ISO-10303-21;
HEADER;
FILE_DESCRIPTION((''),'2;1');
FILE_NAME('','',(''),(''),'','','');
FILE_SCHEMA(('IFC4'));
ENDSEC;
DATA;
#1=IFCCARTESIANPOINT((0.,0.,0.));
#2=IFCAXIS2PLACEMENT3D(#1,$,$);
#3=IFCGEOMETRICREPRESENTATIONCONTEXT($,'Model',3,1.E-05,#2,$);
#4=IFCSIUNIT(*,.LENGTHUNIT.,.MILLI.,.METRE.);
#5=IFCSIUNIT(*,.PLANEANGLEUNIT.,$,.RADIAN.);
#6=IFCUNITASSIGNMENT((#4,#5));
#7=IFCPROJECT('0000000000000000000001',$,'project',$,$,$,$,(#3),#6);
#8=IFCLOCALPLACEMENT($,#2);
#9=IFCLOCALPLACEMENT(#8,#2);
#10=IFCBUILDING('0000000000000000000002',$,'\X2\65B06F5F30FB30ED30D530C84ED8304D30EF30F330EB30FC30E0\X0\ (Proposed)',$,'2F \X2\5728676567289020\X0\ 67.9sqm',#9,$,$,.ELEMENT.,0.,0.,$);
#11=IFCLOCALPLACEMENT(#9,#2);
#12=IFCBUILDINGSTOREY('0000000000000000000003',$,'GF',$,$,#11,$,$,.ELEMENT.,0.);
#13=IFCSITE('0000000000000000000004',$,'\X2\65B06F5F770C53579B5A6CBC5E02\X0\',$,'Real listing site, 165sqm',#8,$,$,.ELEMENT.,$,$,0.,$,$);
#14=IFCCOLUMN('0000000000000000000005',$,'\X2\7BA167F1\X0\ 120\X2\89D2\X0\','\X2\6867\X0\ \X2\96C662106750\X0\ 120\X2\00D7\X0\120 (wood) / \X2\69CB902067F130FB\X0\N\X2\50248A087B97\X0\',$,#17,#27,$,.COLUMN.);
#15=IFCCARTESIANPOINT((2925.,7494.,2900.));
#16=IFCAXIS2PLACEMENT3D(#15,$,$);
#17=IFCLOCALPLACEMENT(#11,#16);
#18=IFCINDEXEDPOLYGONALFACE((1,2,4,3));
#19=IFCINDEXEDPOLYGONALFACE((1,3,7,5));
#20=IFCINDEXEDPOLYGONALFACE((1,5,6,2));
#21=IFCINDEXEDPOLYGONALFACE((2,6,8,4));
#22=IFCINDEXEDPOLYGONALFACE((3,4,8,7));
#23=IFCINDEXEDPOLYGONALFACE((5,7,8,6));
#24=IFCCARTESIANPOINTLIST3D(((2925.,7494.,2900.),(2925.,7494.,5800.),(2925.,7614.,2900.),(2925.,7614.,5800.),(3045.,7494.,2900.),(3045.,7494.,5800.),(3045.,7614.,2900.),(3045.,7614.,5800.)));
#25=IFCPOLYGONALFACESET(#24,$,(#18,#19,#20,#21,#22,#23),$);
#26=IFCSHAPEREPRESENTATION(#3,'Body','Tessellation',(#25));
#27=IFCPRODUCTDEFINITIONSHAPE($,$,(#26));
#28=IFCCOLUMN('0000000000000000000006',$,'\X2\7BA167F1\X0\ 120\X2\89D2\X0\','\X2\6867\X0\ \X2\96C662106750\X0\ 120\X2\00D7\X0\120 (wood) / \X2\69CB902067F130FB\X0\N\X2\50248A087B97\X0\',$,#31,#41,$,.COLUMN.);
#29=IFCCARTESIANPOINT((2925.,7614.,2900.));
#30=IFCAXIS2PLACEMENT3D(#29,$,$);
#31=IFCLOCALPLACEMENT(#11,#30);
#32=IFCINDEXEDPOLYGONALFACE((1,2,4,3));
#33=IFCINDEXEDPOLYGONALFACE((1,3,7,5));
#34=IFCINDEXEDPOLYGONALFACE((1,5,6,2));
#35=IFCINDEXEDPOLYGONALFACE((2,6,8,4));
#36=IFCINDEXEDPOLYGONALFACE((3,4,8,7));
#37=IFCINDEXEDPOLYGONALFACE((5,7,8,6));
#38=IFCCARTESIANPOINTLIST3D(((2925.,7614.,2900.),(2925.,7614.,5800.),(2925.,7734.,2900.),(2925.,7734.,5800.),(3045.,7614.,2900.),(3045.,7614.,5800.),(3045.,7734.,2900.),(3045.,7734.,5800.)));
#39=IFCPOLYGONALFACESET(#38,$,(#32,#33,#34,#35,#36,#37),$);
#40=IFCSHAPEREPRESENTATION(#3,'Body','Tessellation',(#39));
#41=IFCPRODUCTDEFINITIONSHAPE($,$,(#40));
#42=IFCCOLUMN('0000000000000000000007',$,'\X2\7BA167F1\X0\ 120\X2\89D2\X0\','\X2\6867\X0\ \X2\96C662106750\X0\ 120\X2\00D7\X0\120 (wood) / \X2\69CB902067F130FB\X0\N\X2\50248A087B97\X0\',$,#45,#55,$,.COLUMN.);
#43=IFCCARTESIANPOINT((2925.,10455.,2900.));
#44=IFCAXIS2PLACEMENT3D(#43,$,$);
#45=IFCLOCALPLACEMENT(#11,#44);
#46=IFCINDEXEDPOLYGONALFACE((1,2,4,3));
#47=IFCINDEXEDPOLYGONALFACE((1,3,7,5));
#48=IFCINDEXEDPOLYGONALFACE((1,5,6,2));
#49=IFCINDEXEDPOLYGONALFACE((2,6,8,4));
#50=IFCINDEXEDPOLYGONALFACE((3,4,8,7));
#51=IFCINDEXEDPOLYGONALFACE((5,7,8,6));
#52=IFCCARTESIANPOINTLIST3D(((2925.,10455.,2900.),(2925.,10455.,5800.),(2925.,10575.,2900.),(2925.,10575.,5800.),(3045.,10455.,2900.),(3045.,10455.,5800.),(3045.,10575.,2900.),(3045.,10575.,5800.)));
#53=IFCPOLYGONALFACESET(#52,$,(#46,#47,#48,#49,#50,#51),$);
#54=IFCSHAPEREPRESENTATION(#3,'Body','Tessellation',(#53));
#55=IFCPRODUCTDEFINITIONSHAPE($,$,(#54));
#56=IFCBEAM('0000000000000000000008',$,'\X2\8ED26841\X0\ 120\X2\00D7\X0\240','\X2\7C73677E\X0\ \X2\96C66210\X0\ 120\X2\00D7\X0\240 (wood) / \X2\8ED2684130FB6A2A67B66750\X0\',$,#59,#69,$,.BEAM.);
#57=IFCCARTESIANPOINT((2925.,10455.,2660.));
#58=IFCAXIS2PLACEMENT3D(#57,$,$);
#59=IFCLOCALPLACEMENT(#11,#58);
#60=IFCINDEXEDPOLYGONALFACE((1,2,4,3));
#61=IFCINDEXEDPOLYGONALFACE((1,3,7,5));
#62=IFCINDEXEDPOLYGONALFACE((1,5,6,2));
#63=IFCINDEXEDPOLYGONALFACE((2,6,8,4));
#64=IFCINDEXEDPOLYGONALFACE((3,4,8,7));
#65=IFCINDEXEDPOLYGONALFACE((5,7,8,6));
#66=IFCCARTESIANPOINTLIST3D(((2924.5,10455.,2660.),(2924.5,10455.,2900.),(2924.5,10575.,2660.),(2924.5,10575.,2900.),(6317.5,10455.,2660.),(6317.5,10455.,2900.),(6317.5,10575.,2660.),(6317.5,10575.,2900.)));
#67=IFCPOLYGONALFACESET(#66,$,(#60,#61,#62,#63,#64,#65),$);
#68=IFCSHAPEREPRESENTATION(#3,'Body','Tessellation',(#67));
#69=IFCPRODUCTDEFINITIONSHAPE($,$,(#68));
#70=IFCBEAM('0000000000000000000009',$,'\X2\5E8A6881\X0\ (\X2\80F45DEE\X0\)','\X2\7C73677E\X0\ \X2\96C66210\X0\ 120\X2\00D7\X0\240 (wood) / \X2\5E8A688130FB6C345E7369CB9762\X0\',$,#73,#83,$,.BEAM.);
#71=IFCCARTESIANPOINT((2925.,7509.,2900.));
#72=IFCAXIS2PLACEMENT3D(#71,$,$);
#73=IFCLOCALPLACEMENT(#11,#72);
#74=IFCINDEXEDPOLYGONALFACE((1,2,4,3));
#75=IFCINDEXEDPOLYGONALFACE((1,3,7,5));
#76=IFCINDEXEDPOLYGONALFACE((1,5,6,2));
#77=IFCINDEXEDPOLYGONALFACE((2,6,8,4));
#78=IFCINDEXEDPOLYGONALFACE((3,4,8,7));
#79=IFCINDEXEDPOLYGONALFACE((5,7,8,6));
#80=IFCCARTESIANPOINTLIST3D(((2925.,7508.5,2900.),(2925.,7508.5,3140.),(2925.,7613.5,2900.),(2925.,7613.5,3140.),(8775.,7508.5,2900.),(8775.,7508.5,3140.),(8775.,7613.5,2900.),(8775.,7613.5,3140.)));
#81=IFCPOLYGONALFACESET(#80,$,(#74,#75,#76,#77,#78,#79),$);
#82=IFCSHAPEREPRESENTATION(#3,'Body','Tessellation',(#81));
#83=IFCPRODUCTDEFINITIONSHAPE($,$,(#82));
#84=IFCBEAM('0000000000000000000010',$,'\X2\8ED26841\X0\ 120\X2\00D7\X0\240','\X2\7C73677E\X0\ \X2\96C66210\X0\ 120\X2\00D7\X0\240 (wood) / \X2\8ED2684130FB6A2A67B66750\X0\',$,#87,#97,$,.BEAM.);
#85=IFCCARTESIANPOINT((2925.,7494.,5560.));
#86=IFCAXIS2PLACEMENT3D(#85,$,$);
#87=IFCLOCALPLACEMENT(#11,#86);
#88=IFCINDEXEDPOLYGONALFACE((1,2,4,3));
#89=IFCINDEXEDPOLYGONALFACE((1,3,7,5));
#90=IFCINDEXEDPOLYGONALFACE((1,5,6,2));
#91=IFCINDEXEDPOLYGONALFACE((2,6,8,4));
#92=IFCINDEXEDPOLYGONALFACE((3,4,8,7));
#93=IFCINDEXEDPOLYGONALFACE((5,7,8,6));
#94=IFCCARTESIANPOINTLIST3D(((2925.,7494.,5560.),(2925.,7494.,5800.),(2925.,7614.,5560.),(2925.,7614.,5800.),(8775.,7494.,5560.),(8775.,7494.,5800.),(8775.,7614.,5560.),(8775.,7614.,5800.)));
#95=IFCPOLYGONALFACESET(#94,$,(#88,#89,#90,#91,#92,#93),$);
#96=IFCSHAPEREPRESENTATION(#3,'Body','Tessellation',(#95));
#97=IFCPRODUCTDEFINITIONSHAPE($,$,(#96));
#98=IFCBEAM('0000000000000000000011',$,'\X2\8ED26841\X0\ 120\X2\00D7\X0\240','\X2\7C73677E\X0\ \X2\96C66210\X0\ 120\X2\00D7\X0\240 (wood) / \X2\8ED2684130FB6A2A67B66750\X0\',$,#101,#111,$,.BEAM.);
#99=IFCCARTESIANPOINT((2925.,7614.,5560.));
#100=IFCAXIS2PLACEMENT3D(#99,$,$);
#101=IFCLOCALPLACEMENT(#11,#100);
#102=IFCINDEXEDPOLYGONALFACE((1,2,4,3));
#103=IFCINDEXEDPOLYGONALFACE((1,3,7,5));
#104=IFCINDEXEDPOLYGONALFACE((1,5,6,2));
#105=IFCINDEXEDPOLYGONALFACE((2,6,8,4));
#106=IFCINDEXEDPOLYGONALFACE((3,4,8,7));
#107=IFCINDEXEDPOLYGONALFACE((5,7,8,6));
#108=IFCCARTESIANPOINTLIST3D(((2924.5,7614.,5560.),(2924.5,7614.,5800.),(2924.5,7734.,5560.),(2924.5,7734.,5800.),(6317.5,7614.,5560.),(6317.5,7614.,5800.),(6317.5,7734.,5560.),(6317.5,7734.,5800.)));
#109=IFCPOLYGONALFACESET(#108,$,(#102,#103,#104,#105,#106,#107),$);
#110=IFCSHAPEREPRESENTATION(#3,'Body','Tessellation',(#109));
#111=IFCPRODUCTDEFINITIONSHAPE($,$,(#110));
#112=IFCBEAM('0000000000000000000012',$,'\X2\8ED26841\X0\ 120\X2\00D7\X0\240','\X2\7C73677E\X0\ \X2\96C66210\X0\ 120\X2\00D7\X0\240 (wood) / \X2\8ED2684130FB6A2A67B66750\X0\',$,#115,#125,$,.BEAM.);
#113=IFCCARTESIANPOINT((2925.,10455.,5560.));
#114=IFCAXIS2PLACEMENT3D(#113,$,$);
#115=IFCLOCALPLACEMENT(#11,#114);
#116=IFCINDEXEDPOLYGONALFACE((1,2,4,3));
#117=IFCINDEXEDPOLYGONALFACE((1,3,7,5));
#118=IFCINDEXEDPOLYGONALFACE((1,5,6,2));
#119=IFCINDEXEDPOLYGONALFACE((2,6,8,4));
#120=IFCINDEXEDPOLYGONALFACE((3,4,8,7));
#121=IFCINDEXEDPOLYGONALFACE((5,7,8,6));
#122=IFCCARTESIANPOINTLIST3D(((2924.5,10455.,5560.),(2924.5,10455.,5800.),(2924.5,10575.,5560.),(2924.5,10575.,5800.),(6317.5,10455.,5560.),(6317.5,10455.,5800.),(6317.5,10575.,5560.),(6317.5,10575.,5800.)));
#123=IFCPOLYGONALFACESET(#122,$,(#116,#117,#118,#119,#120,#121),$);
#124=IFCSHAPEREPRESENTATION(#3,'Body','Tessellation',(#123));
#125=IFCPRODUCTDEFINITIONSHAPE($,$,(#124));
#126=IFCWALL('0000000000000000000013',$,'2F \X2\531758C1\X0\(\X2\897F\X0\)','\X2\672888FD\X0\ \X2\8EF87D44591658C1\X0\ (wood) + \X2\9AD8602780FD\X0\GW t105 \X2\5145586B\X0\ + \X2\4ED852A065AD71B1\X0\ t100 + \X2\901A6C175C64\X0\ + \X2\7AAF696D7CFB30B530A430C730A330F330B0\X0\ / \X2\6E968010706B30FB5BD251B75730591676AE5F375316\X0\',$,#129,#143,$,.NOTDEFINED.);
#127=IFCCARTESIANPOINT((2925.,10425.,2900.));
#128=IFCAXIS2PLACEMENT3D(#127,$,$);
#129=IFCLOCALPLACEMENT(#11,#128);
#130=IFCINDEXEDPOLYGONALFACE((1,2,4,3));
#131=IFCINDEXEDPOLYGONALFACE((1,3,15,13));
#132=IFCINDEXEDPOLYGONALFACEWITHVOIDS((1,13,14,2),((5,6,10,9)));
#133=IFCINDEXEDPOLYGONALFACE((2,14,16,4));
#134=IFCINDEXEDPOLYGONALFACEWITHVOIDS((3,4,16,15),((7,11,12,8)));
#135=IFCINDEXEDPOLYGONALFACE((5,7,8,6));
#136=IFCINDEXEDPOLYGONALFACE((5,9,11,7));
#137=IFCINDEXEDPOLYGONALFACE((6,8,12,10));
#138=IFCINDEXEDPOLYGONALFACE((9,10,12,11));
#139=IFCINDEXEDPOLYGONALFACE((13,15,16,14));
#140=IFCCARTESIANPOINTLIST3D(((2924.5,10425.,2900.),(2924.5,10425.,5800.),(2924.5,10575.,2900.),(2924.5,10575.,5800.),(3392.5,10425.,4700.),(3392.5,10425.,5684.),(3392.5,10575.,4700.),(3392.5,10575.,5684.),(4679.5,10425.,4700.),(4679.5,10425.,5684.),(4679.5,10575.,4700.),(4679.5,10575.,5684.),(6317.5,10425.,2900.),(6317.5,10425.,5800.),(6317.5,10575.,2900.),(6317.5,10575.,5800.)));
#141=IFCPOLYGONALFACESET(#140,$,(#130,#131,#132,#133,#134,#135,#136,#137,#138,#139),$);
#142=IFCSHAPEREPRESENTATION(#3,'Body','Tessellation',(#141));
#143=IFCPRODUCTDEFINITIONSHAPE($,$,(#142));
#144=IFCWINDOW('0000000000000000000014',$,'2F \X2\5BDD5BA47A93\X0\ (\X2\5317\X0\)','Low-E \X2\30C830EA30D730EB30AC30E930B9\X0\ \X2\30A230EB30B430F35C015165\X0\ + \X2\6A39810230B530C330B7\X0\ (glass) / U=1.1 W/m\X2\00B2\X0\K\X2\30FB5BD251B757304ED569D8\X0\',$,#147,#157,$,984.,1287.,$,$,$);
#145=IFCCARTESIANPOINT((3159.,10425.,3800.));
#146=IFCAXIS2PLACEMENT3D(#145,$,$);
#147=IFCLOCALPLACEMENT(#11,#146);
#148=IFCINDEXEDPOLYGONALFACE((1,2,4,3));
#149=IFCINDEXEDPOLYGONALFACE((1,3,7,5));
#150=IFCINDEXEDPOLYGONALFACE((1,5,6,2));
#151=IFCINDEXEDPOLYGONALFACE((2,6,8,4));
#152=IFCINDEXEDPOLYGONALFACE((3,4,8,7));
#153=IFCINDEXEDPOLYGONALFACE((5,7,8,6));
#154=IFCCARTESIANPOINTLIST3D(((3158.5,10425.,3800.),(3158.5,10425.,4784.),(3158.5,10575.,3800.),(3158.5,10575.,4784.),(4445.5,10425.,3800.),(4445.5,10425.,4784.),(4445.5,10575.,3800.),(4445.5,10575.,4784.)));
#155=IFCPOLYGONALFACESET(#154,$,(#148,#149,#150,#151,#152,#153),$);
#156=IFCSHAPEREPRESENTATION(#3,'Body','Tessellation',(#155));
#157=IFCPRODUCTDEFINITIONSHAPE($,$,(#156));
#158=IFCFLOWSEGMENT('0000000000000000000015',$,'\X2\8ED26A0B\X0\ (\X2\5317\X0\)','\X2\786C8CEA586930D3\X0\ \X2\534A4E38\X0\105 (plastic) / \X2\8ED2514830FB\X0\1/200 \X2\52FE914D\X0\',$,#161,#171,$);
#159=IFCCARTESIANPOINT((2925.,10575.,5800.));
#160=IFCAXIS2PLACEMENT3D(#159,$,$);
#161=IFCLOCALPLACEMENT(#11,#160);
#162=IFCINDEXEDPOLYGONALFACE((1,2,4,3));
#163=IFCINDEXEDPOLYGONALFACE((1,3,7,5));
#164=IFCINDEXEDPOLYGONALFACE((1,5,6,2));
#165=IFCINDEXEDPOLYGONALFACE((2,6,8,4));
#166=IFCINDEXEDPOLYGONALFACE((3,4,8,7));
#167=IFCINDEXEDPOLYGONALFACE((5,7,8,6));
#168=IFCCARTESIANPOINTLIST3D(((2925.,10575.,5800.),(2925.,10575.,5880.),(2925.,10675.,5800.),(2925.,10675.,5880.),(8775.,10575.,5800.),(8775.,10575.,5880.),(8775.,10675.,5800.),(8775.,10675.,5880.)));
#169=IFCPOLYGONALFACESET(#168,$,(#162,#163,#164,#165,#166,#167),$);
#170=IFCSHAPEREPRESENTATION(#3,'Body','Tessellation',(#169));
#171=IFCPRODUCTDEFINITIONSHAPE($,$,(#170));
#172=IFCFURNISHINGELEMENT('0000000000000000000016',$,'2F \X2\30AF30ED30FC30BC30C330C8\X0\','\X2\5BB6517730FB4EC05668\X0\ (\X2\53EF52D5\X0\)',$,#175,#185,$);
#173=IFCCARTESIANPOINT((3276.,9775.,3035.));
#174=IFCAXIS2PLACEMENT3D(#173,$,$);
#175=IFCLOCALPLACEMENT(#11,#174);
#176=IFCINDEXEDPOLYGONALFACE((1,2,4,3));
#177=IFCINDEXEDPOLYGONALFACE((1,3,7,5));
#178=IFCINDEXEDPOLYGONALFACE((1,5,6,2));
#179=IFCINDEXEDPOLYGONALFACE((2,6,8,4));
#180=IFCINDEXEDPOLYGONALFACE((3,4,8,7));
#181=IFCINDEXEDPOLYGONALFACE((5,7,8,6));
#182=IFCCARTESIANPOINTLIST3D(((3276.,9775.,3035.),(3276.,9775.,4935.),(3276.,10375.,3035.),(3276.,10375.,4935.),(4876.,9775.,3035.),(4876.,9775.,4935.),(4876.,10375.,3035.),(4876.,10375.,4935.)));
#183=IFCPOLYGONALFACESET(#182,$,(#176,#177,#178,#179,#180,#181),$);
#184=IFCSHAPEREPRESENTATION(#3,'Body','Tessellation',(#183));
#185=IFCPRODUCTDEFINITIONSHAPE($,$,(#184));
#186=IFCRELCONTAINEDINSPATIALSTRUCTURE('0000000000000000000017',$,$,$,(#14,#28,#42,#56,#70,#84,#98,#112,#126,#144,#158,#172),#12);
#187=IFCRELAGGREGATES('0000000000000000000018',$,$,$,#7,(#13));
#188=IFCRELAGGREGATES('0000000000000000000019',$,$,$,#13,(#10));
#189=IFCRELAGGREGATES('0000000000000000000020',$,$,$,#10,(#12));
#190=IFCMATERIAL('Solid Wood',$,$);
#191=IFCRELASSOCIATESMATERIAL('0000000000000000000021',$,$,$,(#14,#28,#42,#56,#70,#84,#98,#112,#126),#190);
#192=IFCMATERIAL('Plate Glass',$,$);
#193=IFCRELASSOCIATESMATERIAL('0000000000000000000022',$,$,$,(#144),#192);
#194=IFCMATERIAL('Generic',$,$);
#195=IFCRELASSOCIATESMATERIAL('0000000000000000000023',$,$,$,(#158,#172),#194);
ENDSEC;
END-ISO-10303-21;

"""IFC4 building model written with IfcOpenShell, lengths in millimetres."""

from ifc_helpers import new_model, si_unit, frame, frame_2d, origin, place, context, project, spatial, rectangle, extrude, material, element, fill, save


model = new_model("IFC4")

# Units and contexts
model_context = context("Model", 3, precision=1e-05, world=origin())
ifc_project = project(units=[si_unit("LENGTHUNIT", "METRE", prefix="MILLI"), si_unit("PLANEANGLEUNIT", "RADIAN")], contexts=[model_context])

# Site, building, storey
site_placement = place(None, origin())
site = spatial("IfcSite", under=ifc_project, at=site_placement, Name="新潟県南魚沼市", ObjectType="Real listing site, 165sqm", CompositionType="ELEMENT", RefElevation=0.0)
building_placement = place(site_placement, origin())
building = spatial("IfcBuilding", under=site, at=building_placement, Name="新潟・ロフト付きワンルーム (Proposed)", ObjectType="2F 在来木造 67.9sqm", CompositionType="ELEMENT", ElevationOfRefHeight=0.0, ElevationOfTerrain=0.0)
storey_placement = place(building_placement, origin())
storey = spatial("IfcBuildingStorey", under=building, at=storey_placement, Name="GF", CompositionType="ELEMENT", Elevation=0.0)

# Columns
ifc_material_1 = material(Name="Solid Wood")
column_1_placement = place(storey_placement, frame((2925.0, 7494.0, 2900.0)))
element("IfcColumn", 1, at=column_1_placement, inside=storey, material=ifc_material_1, Name="管柱 120角", Description="桧 集成材 120×120 (wood) / 構造柱・N値計算", PredefinedType="COLUMN", context=model_context, shape_type="SweptSolid", body=[
    extrude(rectangle(XDim=120.0, YDim=120.0, at=frame_2d((60.0, 60.0))), frame((2925.0, 7494.0, 2900.0)), (0.0, 0.0, 1.0), 2900.0),
])
column_2_placement = place(storey_placement, frame((2925.0, 7614.0, 2900.0)))
element("IfcColumn", 2, at=column_2_placement, inside=storey, material=ifc_material_1, Name="管柱 120角", Description="桧 集成材 120×120 (wood) / 構造柱・N値計算", PredefinedType="COLUMN", context=model_context, shape_type="SweptSolid", body=[
    extrude(rectangle(XDim=120.0, YDim=120.0, at=frame_2d((60.0, 60.0))), frame((2925.0, 7614.0, 2900.0)), (0.0, 0.0, 1.0), 2900.0),
])
column_3_placement = place(storey_placement, frame((2925.0, 10455.0, 2900.0)))
element("IfcColumn", 3, at=column_3_placement, inside=storey, material=ifc_material_1, Name="管柱 120角", Description="桧 集成材 120×120 (wood) / 構造柱・N値計算", PredefinedType="COLUMN", context=model_context, shape_type="SweptSolid", body=[
    extrude(rectangle(XDim=120.0, YDim=120.0, at=frame_2d((60.0, 60.0))), frame((2925.0, 10455.0, 2900.0)), (0.0, 0.0, 1.0), 2900.0),
])

# Beams
beam_1_placement = place(storey_placement, frame((2925.0, 10455.0, 2660.0)))
element("IfcBeam", 4, at=beam_1_placement, inside=storey, material=ifc_material_1, Name="軒桁 120×240", Description="米松 集成 120×240 (wood) / 軒桁・横架材", PredefinedType="BEAM", context=model_context, shape_type="SweptSolid", body=[
    extrude(rectangle(XDim=3393.0, YDim=120.0, at=frame_2d((1696.0, 60.0))), frame((2925.0, 10455.0, 2660.0)), (0.0, 0.0, 1.0), 240.0),
])
beam_2_placement = place(storey_placement, frame((2925.0, 7509.0, 2900.0)))
element("IfcBeam", 5, at=beam_2_placement, inside=storey, material=ifc_material_1, Name="床梁 (胴差)", Description="米松 集成 120×240 (wood) / 床梁・水平構面", PredefinedType="BEAM", context=model_context, shape_type="SweptSolid", body=[
    extrude(rectangle(XDim=5850.0, YDim=105.0, at=frame_2d((2925.0, 52.0))), frame((2925.0, 7509.0, 2900.0)), (0.0, 0.0, 1.0), 240.0),
])
beam_3_placement = place(storey_placement, frame((2925.0, 7494.0, 5560.0)))
element("IfcBeam", 6, at=beam_3_placement, inside=storey, material=ifc_material_1, Name="軒桁 120×240", Description="米松 集成 120×240 (wood) / 軒桁・横架材", PredefinedType="BEAM", context=model_context, shape_type="SweptSolid", body=[
    extrude(rectangle(XDim=5850.0, YDim=120.0, at=frame_2d((2925.0, 60.0))), frame((2925.0, 7494.0, 5560.0)), (0.0, 0.0, 1.0), 240.0),
])
beam_4_placement = place(storey_placement, frame((2925.0, 7614.0, 5560.0)))
element("IfcBeam", 7, at=beam_4_placement, inside=storey, material=ifc_material_1, Name="軒桁 120×240", Description="米松 集成 120×240 (wood) / 軒桁・横架材", PredefinedType="BEAM", context=model_context, shape_type="SweptSolid", body=[
    extrude(rectangle(XDim=3393.0, YDim=120.0, at=frame_2d((1696.0, 60.0))), frame((2925.0, 7614.0, 5560.0)), (0.0, 0.0, 1.0), 240.0),
])
beam_5_placement = place(storey_placement, frame((2925.0, 10455.0, 5560.0)))
element("IfcBeam", 8, at=beam_5_placement, inside=storey, material=ifc_material_1, Name="軒桁 120×240", Description="米松 集成 120×240 (wood) / 軒桁・横架材", PredefinedType="BEAM", context=model_context, shape_type="SweptSolid", body=[
    extrude(rectangle(XDim=3393.0, YDim=120.0, at=frame_2d((1696.0, 60.0))), frame((2925.0, 10455.0, 5560.0)), (0.0, 0.0, 1.0), 240.0),
])

# Wall, opening, window
wall_1_placement = place(storey_placement, frame((2925.0, 10425.0, 2900.0)))
wall_1 = element("IfcWall", 9, at=wall_1_placement, inside=storey, material=ifc_material_1, Name="2F 北壁(西)", Description="木製 軸組外壁 (wood) + 高性能GW t105 充填 + 付加断熱 t100 + 通気層 + 窯業系サイディング / 準耐火・寒冷地外皮強化", PredefinedType="NOTDEFINED", context=model_context, shape_type="SweptSolid", body=[
    extrude(rectangle(XDim=3393.0, YDim=150.0, at=frame_2d((1696.0, 75.0))), frame((2925.0, 10425.0, 2900.0)), (0.0, 0.0, 1.0), 2900.0),
])
opening_placement = place(storey_placement, frame((3159.0, 10425.0, 3800.0)))
opening = element("IfcOpeningElement", 10, at=opening_placement, cuts=wall_1, PredefinedType="NOTDEFINED", context=model_context, shape_type="SweptSolid", body=[
    extrude(rectangle(XDim=1287.0, YDim=150.0, at=frame_2d((643.0, 75.0))), frame((3159.0, 10425.0, 3800.0)), (0.0, 0.0, 1.0), 984.0),
])
ifc_material_2 = material(Name="Plate Glass")
window_placement = place(storey_placement, frame((3159.0, 10425.0, 3800.0)))
window = element("IfcWindow", 11, at=window_placement, inside=storey, material=ifc_material_2, Name="2F 寝室窓 (北)", Description="Low-E トリプルガラス アルゴン封入 + 樹脂サッシ (glass) / U=1.1 W/m²K・寒冷地仕様", OverallHeight=984.0, OverallWidth=1287.0, context=model_context, shape_type="SweptSolid", body=[
    extrude(rectangle(XDim=1287.0, YDim=150.0, at=frame_2d((643.0, 75.0))), frame((3159.0, 10425.0, 3800.0)), (0.0, 0.0, 1.0), 984.0),
])
fill(opening, window)

# Shared definitions
ifc_material_3 = material(Name="Generic")

# Flow segment
flow_segment_placement = place(storey_placement, frame((2925.0, 10575.0, 5800.0)))
element("IfcFlowSegment", 12, at=flow_segment_placement, inside=storey, material=ifc_material_3, Name="軒樋 (北)", Description="硬質塩ビ 半丸105 (plastic) / 軒先・1/200 勾配", context=model_context, shape_type="SweptSolid", body=[
    extrude(rectangle(XDim=5850.0, YDim=100.0, at=frame_2d((2925.0, 50.0))), frame((2925.0, 10575.0, 5800.0)), (0.0, 0.0, 1.0), 80.0),
])

# Furnishing element
furnishing_placement = place(storey_placement, frame((3276.0, 9775.0, 3035.0)))
element("IfcFurnishingElement", 13, at=furnishing_placement, inside=storey, material=ifc_material_3, Name="2F クローゼット", Description="家具・什器 (可動)", context=model_context, shape_type="SweptSolid", body=[
    extrude(rectangle(XDim=1600.0, YDim=600.0, at=frame_2d((800.0, 300.0))), frame((3276.0, 9775.0, 3035.0)), (0.0, 0.0, 1.0), 1900.0),
])

save(model, "model.ifc")
